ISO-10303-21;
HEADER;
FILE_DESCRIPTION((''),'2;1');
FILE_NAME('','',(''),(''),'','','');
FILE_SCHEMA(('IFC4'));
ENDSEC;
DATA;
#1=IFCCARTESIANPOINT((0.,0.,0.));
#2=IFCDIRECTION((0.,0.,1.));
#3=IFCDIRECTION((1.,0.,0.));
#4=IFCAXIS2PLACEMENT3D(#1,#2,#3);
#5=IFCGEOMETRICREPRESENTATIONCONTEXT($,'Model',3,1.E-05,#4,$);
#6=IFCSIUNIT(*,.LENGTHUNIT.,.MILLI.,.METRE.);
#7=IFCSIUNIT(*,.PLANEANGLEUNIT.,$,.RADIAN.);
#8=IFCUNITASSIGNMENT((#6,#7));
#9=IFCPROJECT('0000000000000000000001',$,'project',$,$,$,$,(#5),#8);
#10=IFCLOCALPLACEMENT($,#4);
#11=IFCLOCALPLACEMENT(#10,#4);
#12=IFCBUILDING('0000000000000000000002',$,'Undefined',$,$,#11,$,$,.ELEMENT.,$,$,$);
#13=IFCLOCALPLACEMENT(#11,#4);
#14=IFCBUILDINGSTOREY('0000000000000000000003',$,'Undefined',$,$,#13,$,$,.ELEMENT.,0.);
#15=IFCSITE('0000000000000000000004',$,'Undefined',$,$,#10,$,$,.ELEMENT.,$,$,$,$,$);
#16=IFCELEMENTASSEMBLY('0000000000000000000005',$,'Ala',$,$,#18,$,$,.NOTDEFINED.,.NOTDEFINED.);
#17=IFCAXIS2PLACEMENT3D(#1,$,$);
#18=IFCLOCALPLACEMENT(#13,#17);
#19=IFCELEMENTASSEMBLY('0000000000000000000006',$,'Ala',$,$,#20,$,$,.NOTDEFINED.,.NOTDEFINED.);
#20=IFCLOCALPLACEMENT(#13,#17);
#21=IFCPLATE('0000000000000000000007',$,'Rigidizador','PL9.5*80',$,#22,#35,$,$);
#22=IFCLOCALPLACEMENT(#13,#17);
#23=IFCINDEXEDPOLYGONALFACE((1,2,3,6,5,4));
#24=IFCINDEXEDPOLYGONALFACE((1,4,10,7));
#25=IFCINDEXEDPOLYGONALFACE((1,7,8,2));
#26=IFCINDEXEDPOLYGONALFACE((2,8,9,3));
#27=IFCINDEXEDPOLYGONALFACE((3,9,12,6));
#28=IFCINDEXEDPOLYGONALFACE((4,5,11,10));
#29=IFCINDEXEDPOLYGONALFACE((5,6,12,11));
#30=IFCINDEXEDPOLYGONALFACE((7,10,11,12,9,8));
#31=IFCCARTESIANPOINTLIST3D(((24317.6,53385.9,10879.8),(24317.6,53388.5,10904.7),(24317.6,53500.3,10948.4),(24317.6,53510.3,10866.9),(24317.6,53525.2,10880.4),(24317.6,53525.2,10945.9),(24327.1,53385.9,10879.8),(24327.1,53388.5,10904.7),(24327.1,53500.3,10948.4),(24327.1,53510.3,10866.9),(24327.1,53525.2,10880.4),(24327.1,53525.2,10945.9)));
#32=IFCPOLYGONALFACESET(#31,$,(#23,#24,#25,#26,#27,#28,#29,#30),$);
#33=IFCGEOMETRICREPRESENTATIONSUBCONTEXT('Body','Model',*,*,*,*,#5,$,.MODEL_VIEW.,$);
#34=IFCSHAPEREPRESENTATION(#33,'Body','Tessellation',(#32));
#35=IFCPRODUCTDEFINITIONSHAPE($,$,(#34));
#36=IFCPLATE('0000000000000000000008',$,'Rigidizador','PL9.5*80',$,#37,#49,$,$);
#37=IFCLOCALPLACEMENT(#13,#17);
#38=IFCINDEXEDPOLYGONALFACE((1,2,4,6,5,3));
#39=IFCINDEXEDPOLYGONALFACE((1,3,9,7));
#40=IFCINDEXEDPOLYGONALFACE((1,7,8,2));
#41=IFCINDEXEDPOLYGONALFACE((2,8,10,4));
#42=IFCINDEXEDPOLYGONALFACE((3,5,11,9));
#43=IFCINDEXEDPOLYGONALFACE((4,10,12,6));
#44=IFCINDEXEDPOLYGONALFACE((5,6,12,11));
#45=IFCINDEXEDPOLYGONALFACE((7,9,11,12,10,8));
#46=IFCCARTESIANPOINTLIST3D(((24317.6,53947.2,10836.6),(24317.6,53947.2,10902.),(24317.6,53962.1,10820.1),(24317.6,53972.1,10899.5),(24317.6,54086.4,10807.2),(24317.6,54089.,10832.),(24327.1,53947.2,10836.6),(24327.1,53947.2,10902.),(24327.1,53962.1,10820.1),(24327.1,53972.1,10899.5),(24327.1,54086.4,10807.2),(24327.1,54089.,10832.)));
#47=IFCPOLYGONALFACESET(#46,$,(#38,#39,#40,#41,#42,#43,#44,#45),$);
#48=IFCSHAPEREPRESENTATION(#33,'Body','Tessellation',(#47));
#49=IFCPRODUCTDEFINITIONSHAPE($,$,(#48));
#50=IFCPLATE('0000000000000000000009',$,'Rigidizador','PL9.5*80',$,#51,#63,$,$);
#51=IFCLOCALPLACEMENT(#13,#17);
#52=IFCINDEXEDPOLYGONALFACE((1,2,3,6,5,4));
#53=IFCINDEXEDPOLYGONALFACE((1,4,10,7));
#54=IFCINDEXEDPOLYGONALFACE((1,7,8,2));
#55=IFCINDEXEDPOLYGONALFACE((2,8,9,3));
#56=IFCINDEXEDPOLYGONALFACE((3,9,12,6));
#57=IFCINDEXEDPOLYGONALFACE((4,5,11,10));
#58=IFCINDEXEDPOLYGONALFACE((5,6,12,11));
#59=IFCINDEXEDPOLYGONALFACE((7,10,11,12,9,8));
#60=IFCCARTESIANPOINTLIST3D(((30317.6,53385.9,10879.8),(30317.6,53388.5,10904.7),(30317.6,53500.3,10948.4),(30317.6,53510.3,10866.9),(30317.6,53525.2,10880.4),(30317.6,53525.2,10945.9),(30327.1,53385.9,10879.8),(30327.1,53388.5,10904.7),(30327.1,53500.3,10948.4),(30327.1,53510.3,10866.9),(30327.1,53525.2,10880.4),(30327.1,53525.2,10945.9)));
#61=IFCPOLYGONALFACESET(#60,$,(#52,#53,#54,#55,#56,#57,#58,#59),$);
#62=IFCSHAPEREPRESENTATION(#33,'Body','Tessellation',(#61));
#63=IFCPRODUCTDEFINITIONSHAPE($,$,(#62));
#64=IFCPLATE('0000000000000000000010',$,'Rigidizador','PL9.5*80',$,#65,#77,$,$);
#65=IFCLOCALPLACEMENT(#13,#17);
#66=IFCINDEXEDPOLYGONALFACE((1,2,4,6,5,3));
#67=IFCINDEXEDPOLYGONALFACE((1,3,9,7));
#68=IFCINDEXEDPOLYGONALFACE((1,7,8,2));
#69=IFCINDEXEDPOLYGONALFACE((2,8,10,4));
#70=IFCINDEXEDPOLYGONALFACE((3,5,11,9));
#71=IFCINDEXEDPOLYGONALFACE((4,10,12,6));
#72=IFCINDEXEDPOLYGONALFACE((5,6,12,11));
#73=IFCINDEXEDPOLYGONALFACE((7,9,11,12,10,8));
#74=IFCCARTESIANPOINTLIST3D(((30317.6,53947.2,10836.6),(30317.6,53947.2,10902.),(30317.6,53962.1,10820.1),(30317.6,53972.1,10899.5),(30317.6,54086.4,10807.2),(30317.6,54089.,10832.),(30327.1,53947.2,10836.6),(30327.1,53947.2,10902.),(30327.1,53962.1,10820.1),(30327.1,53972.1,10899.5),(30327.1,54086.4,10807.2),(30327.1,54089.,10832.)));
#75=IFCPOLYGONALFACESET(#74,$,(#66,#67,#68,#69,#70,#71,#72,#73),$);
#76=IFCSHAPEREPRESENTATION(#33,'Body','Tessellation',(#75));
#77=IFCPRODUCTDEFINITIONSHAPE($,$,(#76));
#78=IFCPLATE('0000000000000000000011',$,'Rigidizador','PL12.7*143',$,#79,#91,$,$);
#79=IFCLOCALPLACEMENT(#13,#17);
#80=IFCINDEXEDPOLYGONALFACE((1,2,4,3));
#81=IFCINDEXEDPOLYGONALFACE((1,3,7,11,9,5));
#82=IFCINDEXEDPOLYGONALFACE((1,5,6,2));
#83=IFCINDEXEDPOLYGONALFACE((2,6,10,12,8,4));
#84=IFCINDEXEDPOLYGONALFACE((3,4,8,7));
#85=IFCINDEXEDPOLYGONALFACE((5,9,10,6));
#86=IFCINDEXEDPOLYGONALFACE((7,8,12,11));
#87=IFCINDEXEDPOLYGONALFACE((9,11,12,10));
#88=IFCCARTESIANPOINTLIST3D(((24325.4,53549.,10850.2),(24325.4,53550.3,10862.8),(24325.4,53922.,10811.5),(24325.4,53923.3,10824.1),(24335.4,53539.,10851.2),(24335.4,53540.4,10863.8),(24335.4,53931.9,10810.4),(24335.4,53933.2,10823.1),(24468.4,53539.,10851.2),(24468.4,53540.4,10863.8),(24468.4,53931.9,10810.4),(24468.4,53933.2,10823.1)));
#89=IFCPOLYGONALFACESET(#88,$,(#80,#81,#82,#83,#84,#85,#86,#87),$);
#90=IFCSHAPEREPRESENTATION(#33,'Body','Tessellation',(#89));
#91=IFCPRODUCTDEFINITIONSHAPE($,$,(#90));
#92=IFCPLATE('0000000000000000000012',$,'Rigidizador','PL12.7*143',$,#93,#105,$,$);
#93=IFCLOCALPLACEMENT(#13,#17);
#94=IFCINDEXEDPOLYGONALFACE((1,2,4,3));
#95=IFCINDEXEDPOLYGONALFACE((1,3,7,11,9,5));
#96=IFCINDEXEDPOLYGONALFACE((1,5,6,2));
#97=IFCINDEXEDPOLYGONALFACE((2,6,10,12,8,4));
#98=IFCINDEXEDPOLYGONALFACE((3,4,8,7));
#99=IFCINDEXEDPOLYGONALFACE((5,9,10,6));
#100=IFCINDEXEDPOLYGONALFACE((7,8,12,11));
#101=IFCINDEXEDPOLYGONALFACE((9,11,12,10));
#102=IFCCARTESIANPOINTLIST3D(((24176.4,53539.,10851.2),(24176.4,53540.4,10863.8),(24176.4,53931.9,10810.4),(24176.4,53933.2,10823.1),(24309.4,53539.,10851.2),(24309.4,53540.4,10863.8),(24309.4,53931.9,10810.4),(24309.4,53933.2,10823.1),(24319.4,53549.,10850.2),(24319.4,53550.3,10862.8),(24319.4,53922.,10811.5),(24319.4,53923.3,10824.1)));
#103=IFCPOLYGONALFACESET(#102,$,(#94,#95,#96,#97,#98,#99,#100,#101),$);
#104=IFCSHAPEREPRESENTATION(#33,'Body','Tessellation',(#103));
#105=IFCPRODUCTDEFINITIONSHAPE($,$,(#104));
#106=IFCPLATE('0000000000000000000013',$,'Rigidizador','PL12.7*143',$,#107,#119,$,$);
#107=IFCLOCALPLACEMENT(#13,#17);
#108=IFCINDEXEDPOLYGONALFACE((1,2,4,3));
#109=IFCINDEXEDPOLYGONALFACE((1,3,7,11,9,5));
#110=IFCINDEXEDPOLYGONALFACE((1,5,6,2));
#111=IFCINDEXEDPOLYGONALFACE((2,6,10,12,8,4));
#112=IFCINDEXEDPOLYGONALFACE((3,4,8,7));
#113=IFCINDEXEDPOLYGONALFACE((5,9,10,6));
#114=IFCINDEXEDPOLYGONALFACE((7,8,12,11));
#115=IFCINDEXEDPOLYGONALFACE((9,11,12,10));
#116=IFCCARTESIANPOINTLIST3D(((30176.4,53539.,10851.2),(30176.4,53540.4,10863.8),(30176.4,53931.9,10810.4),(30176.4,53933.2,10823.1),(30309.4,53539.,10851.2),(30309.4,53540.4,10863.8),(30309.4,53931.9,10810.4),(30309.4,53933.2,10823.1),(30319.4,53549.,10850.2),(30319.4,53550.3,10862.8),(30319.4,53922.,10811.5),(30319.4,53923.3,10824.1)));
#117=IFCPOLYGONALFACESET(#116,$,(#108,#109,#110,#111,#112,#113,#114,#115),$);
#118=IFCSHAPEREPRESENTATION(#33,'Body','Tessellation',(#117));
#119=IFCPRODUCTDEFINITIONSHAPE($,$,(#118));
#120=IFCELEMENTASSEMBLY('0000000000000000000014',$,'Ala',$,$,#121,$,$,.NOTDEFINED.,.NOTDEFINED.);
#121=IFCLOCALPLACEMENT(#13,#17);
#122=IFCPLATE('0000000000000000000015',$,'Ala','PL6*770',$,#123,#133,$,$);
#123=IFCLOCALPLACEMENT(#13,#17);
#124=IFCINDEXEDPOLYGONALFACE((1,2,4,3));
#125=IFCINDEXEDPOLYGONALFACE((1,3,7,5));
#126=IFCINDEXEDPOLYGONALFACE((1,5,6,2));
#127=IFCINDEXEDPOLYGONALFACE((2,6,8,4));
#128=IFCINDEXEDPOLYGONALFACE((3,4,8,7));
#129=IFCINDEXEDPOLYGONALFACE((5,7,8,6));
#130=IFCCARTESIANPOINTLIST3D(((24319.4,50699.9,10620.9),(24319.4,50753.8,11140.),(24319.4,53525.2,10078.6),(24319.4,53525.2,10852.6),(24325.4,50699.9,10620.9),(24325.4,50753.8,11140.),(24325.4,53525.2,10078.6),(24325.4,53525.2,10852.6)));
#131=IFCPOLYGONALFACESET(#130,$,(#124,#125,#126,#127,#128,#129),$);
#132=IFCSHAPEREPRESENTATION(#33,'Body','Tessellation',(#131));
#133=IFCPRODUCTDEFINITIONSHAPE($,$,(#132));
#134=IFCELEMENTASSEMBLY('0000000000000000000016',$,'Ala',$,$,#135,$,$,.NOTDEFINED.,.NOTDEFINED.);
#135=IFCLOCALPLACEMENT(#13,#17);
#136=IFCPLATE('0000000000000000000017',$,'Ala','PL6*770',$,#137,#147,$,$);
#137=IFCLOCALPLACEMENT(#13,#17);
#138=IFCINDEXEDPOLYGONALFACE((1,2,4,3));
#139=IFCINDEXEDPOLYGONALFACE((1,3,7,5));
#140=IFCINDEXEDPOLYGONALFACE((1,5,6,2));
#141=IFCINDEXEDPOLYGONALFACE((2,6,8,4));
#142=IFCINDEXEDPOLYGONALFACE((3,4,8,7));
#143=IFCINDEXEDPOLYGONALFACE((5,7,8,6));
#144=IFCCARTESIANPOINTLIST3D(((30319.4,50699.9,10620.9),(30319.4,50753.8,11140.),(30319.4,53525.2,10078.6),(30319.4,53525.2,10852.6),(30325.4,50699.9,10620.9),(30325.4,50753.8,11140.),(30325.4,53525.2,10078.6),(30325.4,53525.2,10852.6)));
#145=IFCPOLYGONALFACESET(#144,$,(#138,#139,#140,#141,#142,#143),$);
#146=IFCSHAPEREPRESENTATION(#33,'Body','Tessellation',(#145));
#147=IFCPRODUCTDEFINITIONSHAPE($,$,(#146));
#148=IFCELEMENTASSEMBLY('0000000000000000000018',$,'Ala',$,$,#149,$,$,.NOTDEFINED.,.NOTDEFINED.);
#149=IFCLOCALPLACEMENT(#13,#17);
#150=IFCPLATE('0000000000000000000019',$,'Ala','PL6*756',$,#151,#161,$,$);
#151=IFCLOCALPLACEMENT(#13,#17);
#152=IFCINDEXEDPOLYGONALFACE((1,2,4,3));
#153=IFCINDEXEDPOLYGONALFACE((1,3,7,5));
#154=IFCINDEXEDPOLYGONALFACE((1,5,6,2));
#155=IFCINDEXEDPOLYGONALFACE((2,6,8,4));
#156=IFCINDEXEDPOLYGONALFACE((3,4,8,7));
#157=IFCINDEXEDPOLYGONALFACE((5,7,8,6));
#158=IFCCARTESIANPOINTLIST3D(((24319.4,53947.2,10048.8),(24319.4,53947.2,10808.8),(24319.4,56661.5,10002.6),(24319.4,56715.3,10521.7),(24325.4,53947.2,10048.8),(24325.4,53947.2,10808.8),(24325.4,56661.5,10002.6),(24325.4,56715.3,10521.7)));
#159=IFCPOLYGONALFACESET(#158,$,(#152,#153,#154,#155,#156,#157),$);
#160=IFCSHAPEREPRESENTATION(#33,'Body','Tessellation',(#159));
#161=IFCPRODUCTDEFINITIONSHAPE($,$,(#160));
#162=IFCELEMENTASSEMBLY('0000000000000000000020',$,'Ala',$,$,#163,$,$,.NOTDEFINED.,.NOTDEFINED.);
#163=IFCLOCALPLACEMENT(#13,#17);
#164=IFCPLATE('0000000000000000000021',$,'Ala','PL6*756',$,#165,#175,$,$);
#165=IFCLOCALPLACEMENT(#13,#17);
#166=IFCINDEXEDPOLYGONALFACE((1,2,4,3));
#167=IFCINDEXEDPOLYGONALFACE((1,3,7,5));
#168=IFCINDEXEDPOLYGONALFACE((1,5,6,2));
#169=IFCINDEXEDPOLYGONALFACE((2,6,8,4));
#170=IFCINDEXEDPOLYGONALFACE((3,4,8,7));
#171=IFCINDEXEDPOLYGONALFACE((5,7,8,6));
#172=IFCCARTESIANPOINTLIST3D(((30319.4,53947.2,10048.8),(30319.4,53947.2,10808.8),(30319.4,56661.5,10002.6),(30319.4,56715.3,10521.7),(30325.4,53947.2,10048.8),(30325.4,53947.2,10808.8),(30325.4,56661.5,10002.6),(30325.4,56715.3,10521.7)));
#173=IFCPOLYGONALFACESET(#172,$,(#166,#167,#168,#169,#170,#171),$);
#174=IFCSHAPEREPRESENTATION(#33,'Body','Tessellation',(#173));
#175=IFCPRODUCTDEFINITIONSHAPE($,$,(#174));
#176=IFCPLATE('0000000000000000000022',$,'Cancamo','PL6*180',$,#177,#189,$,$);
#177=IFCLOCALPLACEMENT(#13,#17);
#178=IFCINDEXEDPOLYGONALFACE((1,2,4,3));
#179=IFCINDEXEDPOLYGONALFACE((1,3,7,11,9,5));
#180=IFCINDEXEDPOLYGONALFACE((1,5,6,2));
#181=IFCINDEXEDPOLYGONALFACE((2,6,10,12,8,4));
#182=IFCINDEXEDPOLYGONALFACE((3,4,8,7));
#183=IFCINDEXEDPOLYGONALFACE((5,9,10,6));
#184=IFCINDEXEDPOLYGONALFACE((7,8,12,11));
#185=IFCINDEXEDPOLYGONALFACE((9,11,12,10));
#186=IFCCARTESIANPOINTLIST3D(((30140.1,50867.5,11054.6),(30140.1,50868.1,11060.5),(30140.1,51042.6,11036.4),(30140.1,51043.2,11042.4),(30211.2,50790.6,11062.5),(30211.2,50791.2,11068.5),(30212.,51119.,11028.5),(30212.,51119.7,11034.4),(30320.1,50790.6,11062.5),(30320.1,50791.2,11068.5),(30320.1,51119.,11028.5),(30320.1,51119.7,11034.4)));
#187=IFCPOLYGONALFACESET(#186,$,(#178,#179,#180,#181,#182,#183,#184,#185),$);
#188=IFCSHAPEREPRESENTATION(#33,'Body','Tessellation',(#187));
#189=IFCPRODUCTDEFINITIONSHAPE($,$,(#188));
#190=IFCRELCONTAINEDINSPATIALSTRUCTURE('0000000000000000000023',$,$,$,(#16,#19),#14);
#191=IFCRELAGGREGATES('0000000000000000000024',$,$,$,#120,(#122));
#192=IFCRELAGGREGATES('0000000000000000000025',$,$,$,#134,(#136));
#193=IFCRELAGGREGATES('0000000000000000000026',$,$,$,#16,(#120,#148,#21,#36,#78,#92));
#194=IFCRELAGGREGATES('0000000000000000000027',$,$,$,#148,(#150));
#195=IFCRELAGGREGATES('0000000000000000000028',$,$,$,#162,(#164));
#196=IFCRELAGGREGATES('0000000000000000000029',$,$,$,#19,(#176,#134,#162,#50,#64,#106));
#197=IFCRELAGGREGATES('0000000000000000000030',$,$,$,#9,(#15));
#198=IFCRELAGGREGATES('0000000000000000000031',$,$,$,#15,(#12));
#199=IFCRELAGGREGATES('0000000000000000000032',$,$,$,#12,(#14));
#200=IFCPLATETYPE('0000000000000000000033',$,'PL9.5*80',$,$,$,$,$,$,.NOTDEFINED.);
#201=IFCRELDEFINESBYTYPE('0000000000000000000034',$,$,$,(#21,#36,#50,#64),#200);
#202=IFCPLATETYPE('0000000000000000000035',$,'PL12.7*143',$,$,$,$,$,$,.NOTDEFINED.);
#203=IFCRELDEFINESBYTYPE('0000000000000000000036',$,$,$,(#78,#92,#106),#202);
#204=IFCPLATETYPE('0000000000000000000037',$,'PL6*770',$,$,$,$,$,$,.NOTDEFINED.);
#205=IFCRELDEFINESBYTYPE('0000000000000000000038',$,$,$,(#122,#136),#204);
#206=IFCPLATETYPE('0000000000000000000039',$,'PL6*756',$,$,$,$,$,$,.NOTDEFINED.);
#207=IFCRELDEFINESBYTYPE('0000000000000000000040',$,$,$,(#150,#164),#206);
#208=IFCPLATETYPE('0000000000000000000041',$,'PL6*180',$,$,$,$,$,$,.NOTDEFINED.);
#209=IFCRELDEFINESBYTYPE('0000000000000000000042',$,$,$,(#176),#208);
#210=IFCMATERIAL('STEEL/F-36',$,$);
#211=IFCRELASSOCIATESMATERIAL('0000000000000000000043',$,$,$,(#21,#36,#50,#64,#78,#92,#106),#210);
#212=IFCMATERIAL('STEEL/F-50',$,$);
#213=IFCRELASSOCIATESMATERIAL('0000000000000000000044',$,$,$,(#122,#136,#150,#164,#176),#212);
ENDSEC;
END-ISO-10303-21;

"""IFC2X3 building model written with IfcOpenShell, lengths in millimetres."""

from ifc_helpers import new_model, si_unit, frame, origin_with_axes, place, context, subcontext, project, spatial, polyline, outline, extrude, material, type_object, element, aggregate, save


model = new_model("IFC2X3")

# Units and contexts
model_context = context("Model", 3, precision=1e-05, world=origin_with_axes())
body_context = subcontext(model_context, "Body", "Model", "MODEL_VIEW")
ifc_project = project(units=[si_unit("LENGTHUNIT", "METRE", prefix="MILLI"), si_unit("PLANEANGLEUNIT", "RADIAN")], contexts=[model_context])

# Site, building, storey
site_placement = place(None, origin_with_axes())
site = spatial("IfcSite", under=ifc_project, at=site_placement, Name="Undefined", CompositionType="ELEMENT")
building_placement = place(site_placement, origin_with_axes())
building = spatial("IfcBuilding", under=site, at=building_placement, Name="Undefined", CompositionType="ELEMENT")
storey_placement = place(building_placement, origin_with_axes())
storey = spatial("IfcBuildingStorey", under=building, at=storey_placement, Name="Undefined", CompositionType="ELEMENT", Elevation=0.0)

# Element assemblies
assembly_1_placement = place(storey_placement, origin_with_axes())
assembly_1 = element("IfcElementAssembly", 1, at=assembly_1_placement, inside=storey, Name="Ala", AssemblyPlace="NOTDEFINED", PredefinedType="NOTDEFINED")
ifc_material_1 = material(Name="STEEL/F-50")
assembly_2_placement = place(storey_placement, origin_with_axes())
assembly_2 = element("IfcElementAssembly", 2, at=assembly_2_placement, inside=storey, Name="Ala", AssemblyPlace="NOTDEFINED", PredefinedType="NOTDEFINED")

# Plates
ifc_material_2 = material(Name="STEEL/F-36")
plate_type_1 = type_object("IfcPlateType", Name="PL9.5*80", PredefinedType="NOTDEFINED")
plate_1_placement = place(assembly_1_placement, frame((24322.4, 53500.3, 10948.4), z_axis=(-1.0, 0.0, 0.0), x_axis=(0.0, 0.994633, -0.103465)))
plate_1 = element("IfcPlate", 3, at=plate_1_placement, type_object=plate_type_1, material=ifc_material_2, Name="Rigidizador", Description="PL9.5*80", context=body_context, shape_type="SweptSolid", body=[
    extrude(outline(polyline([(0.0, 0.0), (25.0, 0.0), (31.8, 65.1), (18.3, 80.1), (-106.7, 80.1), (-106.7, 55.1), (0.0, 0.0)])), frame((0.0, 0.0, -4.8), z_axis=(0.0, 0.0, 1.0), x_axis=(1.0, 0.0, 0.0)), (0.0, 0.0, 1.0), 9.5),
])
plate_2_placement = place(assembly_1_placement, frame((24322.4, 53972.1, 10899.5), z_axis=(1.0, 0.0, 0.0), x_axis=(0.0, -0.994665, 0.103162)))
plate_2 = element("IfcPlate", 4, at=plate_2_placement, type_object=plate_type_1, material=ifc_material_2, Name="Rigidizador", Description="PL9.5*80", context=body_context, shape_type="SweptSolid", body=[
    extrude(outline(polyline([(0.0, 0.0), (25.0, 0.0), (18.3, 65.1), (1.7, 80.0), (-123.3, 80.0), (-123.3, 55.0), (0.0, 0.0)])), frame((0.0, 0.0, -4.8), z_axis=(0.0, 0.0, 1.0), x_axis=(1.0, 0.0, 0.0)), (0.0, 0.0, 1.0), 9.5),
])
plate_3_placement = place(assembly_2_placement, frame((30322.4, 53500.3, 10948.4), z_axis=(-1.0, 0.0, 0.0), x_axis=(0.0, 0.994633, -0.103465)))
plate_3 = element("IfcPlate", 5, at=plate_3_placement, type_object=plate_type_1, material=ifc_material_2, Name="Rigidizador", Description="PL9.5*80", context=body_context, shape_type="SweptSolid", body=[
    extrude(outline(polyline([(0.0, 0.0), (25.0, 0.0), (31.8, 65.1), (18.3, 80.1), (-106.7, 80.1), (-106.7, 55.1), (0.0, 0.0)])), frame((0.0, 0.0, -4.8), z_axis=(0.0, 0.0, 1.0), x_axis=(1.0, 0.0, 0.0)), (0.0, 0.0, 1.0), 9.5),
])
plate_4_placement = place(assembly_2_placement, frame((30322.4, 53972.1, 10899.5), z_axis=(1.0, 0.0, 0.0), x_axis=(0.0, -0.994665, 0.103162)))
plate_4 = element("IfcPlate", 6, at=plate_4_placement, type_object=plate_type_1, material=ifc_material_2, Name="Rigidizador", Description="PL9.5*80", context=body_context, shape_type="SweptSolid", body=[
    extrude(outline(polyline([(0.0, 0.0), (25.0, 0.0), (18.3, 65.1), (1.7, 80.0), (-123.3, 80.0), (-123.3, 55.0), (0.0, 0.0)])), frame((0.0, 0.0, -4.8), z_axis=(0.0, 0.0, 1.0), x_axis=(1.0, 0.0, 0.0)), (0.0, 0.0, 1.0), 9.5),
])
plate_type_2 = type_object("IfcPlateType", Name="PL12.7*143", PredefinedType="NOTDEFINED")
plate_5_placement = place(assembly_1_placement, frame((24325.4, 53539.7, 10857.5), z_axis=(0.0, 0.103246, 0.994656), x_axis=(1.0, 0.0, 0.0)))
plate_5 = element("IfcPlate", 7, at=plate_5_placement, type_object=plate_type_2, material=ifc_material_2, Name="Rigidizador", Description="PL12.7*143", context=body_context, shape_type="SweptSolid", body=[
    extrude(outline(polyline([(0.0, 10.0), (10.0, 0.0), (143.0, 0.0), (143.0, 395.0), (10.0, 395.0), (0.0, 385.0), (0.0, 10.0)])), frame((0.0, 0.0, -6.3), z_axis=(0.0, 0.0, 1.0), x_axis=(1.0, 0.0, 0.0)), (0.0, 0.0, 1.0), 12.7),
])
plate_6_placement = place(assembly_1_placement, frame((24319.4, 53539.7, 10857.5), z_axis=(0.0, -0.103246, -0.994656), x_axis=(-1.0, 0.0, 0.0)))
plate_6 = element("IfcPlate", 8, at=plate_6_placement, type_object=plate_type_2, material=ifc_material_2, Name="Rigidizador", Description="PL12.7*143", context=body_context, shape_type="SweptSolid", body=[
    extrude(outline(polyline([(0.0, 10.0), (10.0, 0.0), (143.0, 0.0), (143.0, 395.0), (10.0, 395.0), (0.0, 385.0), (0.0, 10.0)])), frame((0.0, 0.0, -6.3), z_axis=(0.0, 0.0, 1.0), x_axis=(1.0, 0.0, 0.0)), (0.0, 0.0, 1.0), 12.7),
])
plate_7_placement = place(assembly_2_placement, frame((30319.4, 53539.7, 10857.5), z_axis=(0.0, -0.103246, -0.994656), x_axis=(-1.0, 0.0, 0.0)))
plate_7 = element("IfcPlate", 9, at=plate_7_placement, type_object=plate_type_2, material=ifc_material_2, Name="Rigidizador", Description="PL12.7*143", context=body_context, shape_type="SweptSolid", body=[
    extrude(outline(polyline([(0.0, 10.0), (10.0, 0.0), (143.0, 0.0), (143.0, 395.0), (10.0, 395.0), (0.0, 385.0), (0.0, 10.0)])), frame((0.0, 0.0, -6.3), z_axis=(0.0, 0.0, 1.0), x_axis=(1.0, 0.0, 0.0)), (0.0, 0.0, 1.0), 12.7),
])

# Element assemblies, plates
assembly_3_placement = place(assembly_1_placement, origin_with_axes())
assembly_3 = element("IfcElementAssembly", 10, at=assembly_3_placement, Name="Ala", AssemblyPlace="NOTDEFINED", PredefinedType="NOTDEFINED")
plate_type_3 = type_object("IfcPlateType", Name="PL6*770", PredefinedType="NOTDEFINED")
plate_8_placement = place(assembly_3_placement, frame((24322.4, 53525.2, 10852.6), z_axis=(1.0, 0.0, 0.0), x_axis=(0.0, -0.994664, 0.103164)))
plate_8 = element("IfcPlate", 11, at=plate_8_placement, type_object=plate_type_3, material=ifc_material_1, Name="Ala", Description="PL6*770", context=body_context, shape_type="SweptSolid", body=[
    extrude(outline(polyline([(0.0, 0.0), (2786.3, 0.0), (2786.3, 522.0), (-79.8, 769.8), (0.0, 0.0)])), frame((0.0, 0.0, -3.0), z_axis=(0.0, 0.0, 1.0), x_axis=(1.0, 0.0, 0.0)), (0.0, 0.0, 1.0), 6.0),
])
aggregate(assembly_3, [plate_8])
assembly_4_placement = place(assembly_2_placement, origin_with_axes())
assembly_4 = element("IfcElementAssembly", 12, at=assembly_4_placement, Name="Ala", AssemblyPlace="NOTDEFINED", PredefinedType="NOTDEFINED")
plate_9_placement = place(assembly_4_placement, frame((30322.4, 53525.2, 10852.6), z_axis=(1.0, 0.0, 0.0), x_axis=(0.0, -0.994664, 0.103164)))
plate_9 = element("IfcPlate", 13, at=plate_9_placement, type_object=plate_type_3, material=ifc_material_1, Name="Ala", Description="PL6*770", context=body_context, shape_type="SweptSolid", body=[
    extrude(outline(polyline([(0.0, 0.0), (2786.3, 0.0), (2786.3, 522.0), (-79.8, 769.8), (0.0, 0.0)])), frame((0.0, 0.0, -3.0), z_axis=(0.0, 0.0, 1.0), x_axis=(1.0, 0.0, 0.0)), (0.0, 0.0, 1.0), 6.0),
])
aggregate(assembly_4, [plate_9])

# Element assembly
assembly_5_placement = place(assembly_1_placement, origin_with_axes())
assembly_5 = element("IfcElementAssembly", 14, at=assembly_5_placement, Name="Ala", AssemblyPlace="NOTDEFINED", PredefinedType="NOTDEFINED")
aggregate(assembly_1, [assembly_3, assembly_5, plate_1, plate_2, plate_5, plate_6])

# Plate
plate_type_4 = type_object("IfcPlateType", Name="PL6*756", PredefinedType="NOTDEFINED")
plate_10_placement = place(assembly_5_placement, frame((24322.4, 53947.2, 10808.8), z_axis=(-1.0, 0.0, 0.0), x_axis=(0.0, 0.994665, -0.103162)))
plate_10 = element("IfcPlate", 15, at=plate_10_placement, type_object=plate_type_4, material=ifc_material_1, Name="Ala", Description="PL6*756", context=body_context, shape_type="SweptSolid", body=[
    extrude(outline(polyline([(0.0, 0.0), (2783.0, 0.0), (2783.0, 521.9), (78.4, 755.9), (0.0, 0.0)])), frame((0.0, 0.0, -3.0), z_axis=(0.0, 0.0, 1.0), x_axis=(1.0, 0.0, 0.0)), (0.0, 0.0, 1.0), 6.0),
])
aggregate(assembly_5, [plate_10])

# Element assembly, plate
assembly_6_placement = place(assembly_2_placement, origin_with_axes())
assembly_6 = element("IfcElementAssembly", 16, at=assembly_6_placement, Name="Ala", AssemblyPlace="NOTDEFINED", PredefinedType="NOTDEFINED")
plate_11_placement = place(assembly_6_placement, frame((30322.4, 53947.2, 10808.8), z_axis=(-1.0, 0.0, 0.0), x_axis=(0.0, 0.994665, -0.103162)))
plate_11 = element("IfcPlate", 17, at=plate_11_placement, type_object=plate_type_4, material=ifc_material_1, Name="Ala", Description="PL6*756", context=body_context, shape_type="SweptSolid", body=[
    extrude(outline(polyline([(0.0, 0.0), (2783.0, 0.0), (2783.0, 521.9), (78.4, 755.9), (0.0, 0.0)])), frame((0.0, 0.0, -3.0), z_axis=(0.0, 0.0, 1.0), x_axis=(1.0, 0.0, 0.0)), (0.0, 0.0, 1.0), 6.0),
])
aggregate(assembly_6, [plate_11])

# Plate
plate_type_5 = type_object("IfcPlateType", Name="PL6*180", PredefinedType="NOTDEFINED")
plate_12_placement = place(assembly_2_placement, frame((30320.1, 51119.4, 11031.5), z_axis=(0.0, -0.103162, -0.994665), x_axis=(0.0, -0.994665, 0.103162)))
plate_12 = element("IfcPlate", 18, at=plate_12_placement, type_object=plate_type_5, material=ifc_material_1, Name="Cancamo", Description="PL6*180", context=body_context, shape_type="SweptSolid", body=[
    extrude(outline(polyline([(0.0, 0.0), (330.2, 0.0), (330.2, 108.9), (252.9, 180.0), (76.9, 180.0), (0.0, 108.1), (0.0, 0.0)])), frame((0.0, 0.0, -3.0), z_axis=(0.0, 0.0, 1.0), x_axis=(1.0, 0.0, 0.0)), (0.0, 0.0, 1.0), 6.0),
])
aggregate(assembly_2, [plate_12, assembly_4, assembly_6, plate_3, plate_4, plate_7])

save(model, "model.ifc")
